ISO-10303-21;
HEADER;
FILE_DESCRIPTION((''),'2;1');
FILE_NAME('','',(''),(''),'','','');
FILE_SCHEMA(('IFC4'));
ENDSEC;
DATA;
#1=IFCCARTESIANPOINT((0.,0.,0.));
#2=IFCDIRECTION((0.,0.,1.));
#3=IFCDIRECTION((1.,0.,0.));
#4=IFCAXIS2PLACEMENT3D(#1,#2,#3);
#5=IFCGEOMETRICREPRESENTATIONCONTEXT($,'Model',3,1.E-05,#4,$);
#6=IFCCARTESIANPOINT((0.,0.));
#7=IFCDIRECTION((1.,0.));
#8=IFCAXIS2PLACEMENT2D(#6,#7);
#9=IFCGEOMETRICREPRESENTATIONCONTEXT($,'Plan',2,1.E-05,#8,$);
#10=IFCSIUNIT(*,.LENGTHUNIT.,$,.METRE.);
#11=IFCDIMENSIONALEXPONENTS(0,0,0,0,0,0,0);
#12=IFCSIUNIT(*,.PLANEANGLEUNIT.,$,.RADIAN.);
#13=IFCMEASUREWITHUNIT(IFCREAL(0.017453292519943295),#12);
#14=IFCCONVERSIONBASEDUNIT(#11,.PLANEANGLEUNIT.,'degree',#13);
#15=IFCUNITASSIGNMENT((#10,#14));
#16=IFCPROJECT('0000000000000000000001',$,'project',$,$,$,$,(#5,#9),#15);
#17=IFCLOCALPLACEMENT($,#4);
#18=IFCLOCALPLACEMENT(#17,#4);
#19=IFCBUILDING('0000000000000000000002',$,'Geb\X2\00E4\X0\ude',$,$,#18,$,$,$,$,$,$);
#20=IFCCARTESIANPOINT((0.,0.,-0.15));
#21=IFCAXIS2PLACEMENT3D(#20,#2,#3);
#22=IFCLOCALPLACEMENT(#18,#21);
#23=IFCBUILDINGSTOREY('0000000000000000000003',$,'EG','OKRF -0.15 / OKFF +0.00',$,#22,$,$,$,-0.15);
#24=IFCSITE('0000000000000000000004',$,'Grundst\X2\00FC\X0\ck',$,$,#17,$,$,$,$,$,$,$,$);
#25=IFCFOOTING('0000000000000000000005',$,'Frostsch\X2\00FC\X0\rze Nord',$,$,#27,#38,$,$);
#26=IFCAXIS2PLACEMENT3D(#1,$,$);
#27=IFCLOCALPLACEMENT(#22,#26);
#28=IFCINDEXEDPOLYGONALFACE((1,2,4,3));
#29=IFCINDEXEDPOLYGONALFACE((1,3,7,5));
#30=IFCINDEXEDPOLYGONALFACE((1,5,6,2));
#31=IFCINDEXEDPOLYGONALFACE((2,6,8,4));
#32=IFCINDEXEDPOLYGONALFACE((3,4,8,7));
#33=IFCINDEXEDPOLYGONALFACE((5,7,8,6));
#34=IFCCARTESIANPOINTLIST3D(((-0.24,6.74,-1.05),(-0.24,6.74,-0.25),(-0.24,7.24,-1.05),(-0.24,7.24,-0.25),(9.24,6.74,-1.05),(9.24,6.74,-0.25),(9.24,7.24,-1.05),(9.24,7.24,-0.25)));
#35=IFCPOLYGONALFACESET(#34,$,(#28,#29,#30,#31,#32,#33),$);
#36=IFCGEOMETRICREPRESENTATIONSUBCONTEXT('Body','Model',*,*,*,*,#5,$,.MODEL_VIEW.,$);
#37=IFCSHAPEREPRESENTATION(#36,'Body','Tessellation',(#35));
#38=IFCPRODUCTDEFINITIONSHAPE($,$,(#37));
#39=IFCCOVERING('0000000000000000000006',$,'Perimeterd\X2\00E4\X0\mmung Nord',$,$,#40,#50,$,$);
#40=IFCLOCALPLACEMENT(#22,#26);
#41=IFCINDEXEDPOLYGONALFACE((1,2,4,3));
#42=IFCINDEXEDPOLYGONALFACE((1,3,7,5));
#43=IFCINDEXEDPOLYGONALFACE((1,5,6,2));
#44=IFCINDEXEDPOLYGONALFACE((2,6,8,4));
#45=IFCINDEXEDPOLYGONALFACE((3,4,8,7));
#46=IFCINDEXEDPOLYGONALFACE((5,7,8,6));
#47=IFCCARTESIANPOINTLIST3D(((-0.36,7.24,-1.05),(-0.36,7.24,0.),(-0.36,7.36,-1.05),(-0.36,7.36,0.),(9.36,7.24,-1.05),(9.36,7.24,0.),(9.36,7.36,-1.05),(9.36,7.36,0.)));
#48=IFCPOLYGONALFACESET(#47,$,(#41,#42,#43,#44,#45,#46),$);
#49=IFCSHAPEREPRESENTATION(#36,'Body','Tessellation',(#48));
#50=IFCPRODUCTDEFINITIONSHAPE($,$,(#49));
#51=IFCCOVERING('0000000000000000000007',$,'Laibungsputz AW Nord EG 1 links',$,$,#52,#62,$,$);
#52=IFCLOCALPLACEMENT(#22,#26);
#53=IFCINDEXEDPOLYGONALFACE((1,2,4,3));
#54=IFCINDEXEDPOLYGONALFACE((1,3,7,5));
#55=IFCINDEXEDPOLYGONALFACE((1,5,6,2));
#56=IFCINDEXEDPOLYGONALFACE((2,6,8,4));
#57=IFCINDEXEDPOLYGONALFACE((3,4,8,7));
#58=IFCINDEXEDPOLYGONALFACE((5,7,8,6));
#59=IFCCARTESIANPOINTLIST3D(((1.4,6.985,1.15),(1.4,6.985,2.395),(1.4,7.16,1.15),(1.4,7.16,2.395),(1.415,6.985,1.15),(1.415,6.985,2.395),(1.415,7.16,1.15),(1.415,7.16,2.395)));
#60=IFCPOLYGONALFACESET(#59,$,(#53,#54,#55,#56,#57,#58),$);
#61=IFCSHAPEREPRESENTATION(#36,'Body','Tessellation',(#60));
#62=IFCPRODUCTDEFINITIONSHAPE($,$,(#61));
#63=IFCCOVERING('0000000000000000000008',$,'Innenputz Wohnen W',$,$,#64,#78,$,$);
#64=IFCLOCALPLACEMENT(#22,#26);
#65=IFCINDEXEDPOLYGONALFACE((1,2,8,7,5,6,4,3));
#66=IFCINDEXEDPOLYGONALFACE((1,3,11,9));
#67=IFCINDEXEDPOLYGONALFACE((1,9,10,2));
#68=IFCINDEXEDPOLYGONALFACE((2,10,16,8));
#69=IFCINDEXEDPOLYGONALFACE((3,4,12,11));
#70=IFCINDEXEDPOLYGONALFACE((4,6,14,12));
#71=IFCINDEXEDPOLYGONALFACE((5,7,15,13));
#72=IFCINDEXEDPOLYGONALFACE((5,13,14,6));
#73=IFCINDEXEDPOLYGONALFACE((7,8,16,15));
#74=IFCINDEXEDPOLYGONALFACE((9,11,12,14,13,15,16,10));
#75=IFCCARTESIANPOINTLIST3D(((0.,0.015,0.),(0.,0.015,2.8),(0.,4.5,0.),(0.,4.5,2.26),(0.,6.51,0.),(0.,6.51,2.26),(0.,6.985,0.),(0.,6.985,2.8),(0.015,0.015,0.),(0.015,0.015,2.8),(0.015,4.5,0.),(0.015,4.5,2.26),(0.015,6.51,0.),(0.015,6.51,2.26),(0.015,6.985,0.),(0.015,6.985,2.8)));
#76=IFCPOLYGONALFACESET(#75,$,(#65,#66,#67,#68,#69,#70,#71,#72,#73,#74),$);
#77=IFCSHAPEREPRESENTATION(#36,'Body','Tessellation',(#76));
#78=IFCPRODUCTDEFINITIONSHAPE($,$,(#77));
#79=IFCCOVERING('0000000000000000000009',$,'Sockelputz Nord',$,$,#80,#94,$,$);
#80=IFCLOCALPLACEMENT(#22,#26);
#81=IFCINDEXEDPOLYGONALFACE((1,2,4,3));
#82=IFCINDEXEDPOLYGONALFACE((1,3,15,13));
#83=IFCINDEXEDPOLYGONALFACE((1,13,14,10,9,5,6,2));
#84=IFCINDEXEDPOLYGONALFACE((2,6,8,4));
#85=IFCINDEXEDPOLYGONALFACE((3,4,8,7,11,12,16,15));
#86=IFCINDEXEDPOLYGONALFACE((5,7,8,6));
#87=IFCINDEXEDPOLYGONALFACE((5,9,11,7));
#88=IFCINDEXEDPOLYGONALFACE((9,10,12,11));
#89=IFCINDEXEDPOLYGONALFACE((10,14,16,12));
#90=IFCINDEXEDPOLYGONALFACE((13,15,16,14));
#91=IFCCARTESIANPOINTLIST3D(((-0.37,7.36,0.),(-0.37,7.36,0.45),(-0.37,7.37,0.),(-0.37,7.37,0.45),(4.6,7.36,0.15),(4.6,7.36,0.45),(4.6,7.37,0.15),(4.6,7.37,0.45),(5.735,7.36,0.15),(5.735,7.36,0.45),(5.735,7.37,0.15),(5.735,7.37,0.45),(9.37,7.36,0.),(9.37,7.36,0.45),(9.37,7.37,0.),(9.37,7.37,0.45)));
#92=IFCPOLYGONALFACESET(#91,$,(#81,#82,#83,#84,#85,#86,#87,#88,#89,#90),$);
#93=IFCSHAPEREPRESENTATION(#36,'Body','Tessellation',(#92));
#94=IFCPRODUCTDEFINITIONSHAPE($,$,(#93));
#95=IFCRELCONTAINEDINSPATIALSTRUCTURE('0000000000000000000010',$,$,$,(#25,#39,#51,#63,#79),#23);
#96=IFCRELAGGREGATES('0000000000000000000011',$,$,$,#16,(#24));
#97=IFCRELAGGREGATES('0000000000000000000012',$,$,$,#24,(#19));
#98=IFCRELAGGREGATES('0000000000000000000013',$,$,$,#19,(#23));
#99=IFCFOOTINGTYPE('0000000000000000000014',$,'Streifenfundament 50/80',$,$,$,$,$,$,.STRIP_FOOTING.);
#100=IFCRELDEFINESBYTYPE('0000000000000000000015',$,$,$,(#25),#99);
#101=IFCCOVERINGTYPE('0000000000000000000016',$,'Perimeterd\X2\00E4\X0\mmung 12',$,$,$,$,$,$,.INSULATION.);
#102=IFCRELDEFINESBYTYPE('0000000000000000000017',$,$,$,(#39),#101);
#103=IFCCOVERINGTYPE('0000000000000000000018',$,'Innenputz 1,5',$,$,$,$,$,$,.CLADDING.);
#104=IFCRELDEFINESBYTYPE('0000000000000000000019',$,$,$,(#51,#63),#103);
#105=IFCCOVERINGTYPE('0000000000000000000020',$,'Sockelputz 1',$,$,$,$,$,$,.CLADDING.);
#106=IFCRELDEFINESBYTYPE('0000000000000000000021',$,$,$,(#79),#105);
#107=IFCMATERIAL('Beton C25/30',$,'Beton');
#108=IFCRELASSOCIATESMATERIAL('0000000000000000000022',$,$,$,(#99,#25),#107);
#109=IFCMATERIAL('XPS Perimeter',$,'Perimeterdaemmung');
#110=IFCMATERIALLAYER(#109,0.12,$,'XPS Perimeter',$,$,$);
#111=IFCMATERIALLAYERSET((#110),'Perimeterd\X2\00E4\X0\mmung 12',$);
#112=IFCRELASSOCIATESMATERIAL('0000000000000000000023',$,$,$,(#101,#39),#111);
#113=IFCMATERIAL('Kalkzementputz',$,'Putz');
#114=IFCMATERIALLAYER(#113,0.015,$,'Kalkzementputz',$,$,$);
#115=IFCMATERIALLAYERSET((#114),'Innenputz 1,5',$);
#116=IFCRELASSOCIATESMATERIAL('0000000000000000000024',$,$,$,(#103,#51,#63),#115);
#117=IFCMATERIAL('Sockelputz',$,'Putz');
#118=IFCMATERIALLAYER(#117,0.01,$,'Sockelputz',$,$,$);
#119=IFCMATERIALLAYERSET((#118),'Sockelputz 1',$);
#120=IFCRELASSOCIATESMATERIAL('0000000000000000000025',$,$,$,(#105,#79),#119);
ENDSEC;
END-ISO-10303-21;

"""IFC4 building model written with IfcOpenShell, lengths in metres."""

from ifc_helpers import new_model, entity, si_unit, converted_unit, frame, origin_with_axes, origin_2d_with_axis, place, context, subcontext, project, spatial, polyline, indexed_curve, rectangle, outline, extrude, material, layer, layer_set, layer_usage, material_profile, profile_set, profile_usage, type_object, element, save


model = new_model("IFC4")

# Units and contexts
model_context = context("Model", 3, precision=1e-05, world=origin_with_axes())
plan_context = context("Plan", 2, precision=1e-05, world=origin_2d_with_axis())
body_context_1 = subcontext(model_context, "Body", "Model", "MODEL_VIEW")
ifc_project = project(units=[si_unit("LENGTHUNIT", "METRE"), converted_unit("PLANEANGLEUNIT", "degree", entity("IfcReal", 0.017453292519943295), si_unit("PLANEANGLEUNIT", "RADIAN"), dimensions=[0, 0, 0, 0, 0, 0, 0])], contexts=[model_context, plan_context])

# Site, building, storey
site_placement = place(None, origin_with_axes())
site = spatial("IfcSite", under=ifc_project, at=site_placement, Name="Grundstück")
building_placement = place(site_placement, origin_with_axes())
building = spatial("IfcBuilding", under=site, at=building_placement, Name="Gebäude")
storey_placement = place(building_placement, frame((0.0, 0.0, -0.15), z_axis=(0.0, 0.0, 1.0), x_axis=(1.0, 0.0, 0.0)))
storey = spatial("IfcBuildingStorey", under=building, at=storey_placement, Name="EG", Description="OKRF -0.15 / OKFF +0.00", Elevation=-0.15)

# Footing
ifc_material_1 = material(Name="Beton C25/30", Category="Beton")
ifc_material_profile = material_profile(ifc_material_1, rectangle(XDim=0.5, YDim=0.8))
ifc_profile_set = profile_set([ifc_material_profile], Name="Streifenfundament 50/80")
ifc_profile_usage = profile_usage(ifc_profile_set)
footing_type = type_object("IfcFootingType", Name="Streifenfundament 50/80", PredefinedType="STRIP_FOOTING", material=ifc_profile_set)
footing_placement = place(storey_placement, frame((-0.24, 6.99, -0.65), z_axis=(1.0, 0.0, 0.0), x_axis=(0.0, 1.0, 0.0)))
element("IfcFooting", 1, at=footing_placement, inside=storey, type_object=footing_type, material=ifc_profile_usage, Name="Frostschürze Nord", context=body_context_1, shape_type="SweptSolid", body=[
    extrude(rectangle(XDim=0.5, YDim=0.8), origin_with_axes(), (0.0, 0.0, 1.0), 9.48),
])

# Coverings
ifc_material_2 = material(Name="XPS Perimeter", Category="Perimeterdaemmung")
ifc_layer_1 = layer(ifc_material_2, 0.12, Name="XPS Perimeter")
ifc_layer_set_1 = layer_set([ifc_layer_1], Name="Perimeterdämmung 12")
ifc_layer_usage_1 = layer_usage(ifc_layer_set_1, "AXIS2", "POSITIVE", 0.0)
covering_type_1 = type_object("IfcCoveringType", Name="Perimeterdämmung 12", PredefinedType="INSULATION", material=ifc_layer_set_1)
covering_1_placement = place(storey_placement, frame((-0.36, 7.24, -1.05), z_axis=(0.0, 0.0, 1.0), x_axis=(1.0, 0.0, 0.0)))
element("IfcCovering", 2, at=covering_1_placement, inside=storey, type_object=covering_type_1, material=ifc_layer_usage_1, Name="Perimeterdämmung Nord", context=body_context_1, shape_type="SweptSolid", body=[
    extrude(outline(indexed_curve([(0.0, 0.0), (0.0, 0.12), (9.72, 0.12), (9.72, 0.0), (0.0, 0.0)], self_intersect=False)), origin_with_axes(), (0.0, 0.0, 1.0), 1.05),
])
ifc_material_3 = material(Name="Kalkzementputz", Category="Putz")
ifc_layer_2 = layer(ifc_material_3, 0.015, Name="Kalkzementputz")
ifc_layer_set_2 = layer_set([ifc_layer_2], Name="Innenputz 1,5")
ifc_layer_usage_2 = layer_usage(ifc_layer_set_2, "AXIS1", "POSITIVE", 1.4)
covering_type_2 = type_object("IfcCoveringType", Name="Innenputz 1,5", PredefinedType="CLADDING", material=ifc_layer_set_2)
covering_2_placement = place(storey_placement, frame((0.0, 7.0, 0.0), z_axis=(0.0, 0.0, 1.0), x_axis=(1.0, 0.0, 0.0)))
element("IfcCovering", 3, at=covering_2_placement, inside=storey, type_object=covering_type_2, material=ifc_layer_usage_2, Name="Laibungsputz AW Nord EG 1 links", context=body_context_1, shape_type="SweptSolid", body=[
    extrude(outline(polyline([(-0.015, 1.15), (0.16, 1.15), (0.16, 2.395), (-0.015, 2.395), (-0.015, 1.15)])), frame((1.4, 0.0, 0.0), z_axis=(1.0, 0.0, 0.0), x_axis=(0.0, 1.0, 0.0)), (0.0, 0.0, 1.0), 0.015),
])

# Covering, opening
ifc_layer_usage_3 = layer_usage(ifc_layer_set_2, "AXIS2", "POSITIVE", 0.0)
covering_3_placement = place(storey_placement, frame((0.0, 6.985, 0.0), z_axis=(0.0, 0.0, 1.0), x_axis=(0.0, -1.0, 0.0)))
covering_3 = element("IfcCovering", 4, at=covering_3_placement, inside=storey, type_object=covering_type_2, material=ifc_layer_usage_3, Name="Innenputz Wohnen W", context=body_context_1, shape_type="SweptSolid", body=[
    extrude(outline(indexed_curve([(0.0, 0.0), (0.0, 0.015), (6.97, 0.015), (6.97, 0.0), (0.0, 0.0)], self_intersect=False)), origin_with_axes(), (0.0, 0.0, 1.0), 2.8),
])
opening_1_placement = place(covering_3_placement, frame((0.475, -0.05, 0.0), z_axis=(0.0, 0.0, 1.0), x_axis=(1.0, 0.0, 0.0)))
element("IfcOpeningElement", 5, at=opening_1_placement, cuts=covering_3, context=body_context_1, shape_type="SweptSolid", body=[
    extrude(outline(indexed_curve([(0.0, 0.0), (0.0, 0.115), (2.01, 0.115), (2.01, 0.0), (0.0, 0.0)], self_intersect=False)), origin_with_axes(), (0.0, 0.0, 1.0), 2.26),
])

# Covering, opening
ifc_material_4 = material(Name="Sockelputz", Category="Putz")
ifc_layer_3 = layer(ifc_material_4, 0.01, Name="Sockelputz")
ifc_layer_set_3 = layer_set([ifc_layer_3], Name="Sockelputz 1")
ifc_layer_usage_4 = layer_usage(ifc_layer_set_3, "AXIS2", "POSITIVE", 0.0)
covering_type_3 = type_object("IfcCoveringType", Name="Sockelputz 1", PredefinedType="CLADDING", material=ifc_layer_set_3)
covering_4_placement = place(storey_placement, frame((-0.37, 7.36, 0.0), z_axis=(0.0, 0.0, 1.0), x_axis=(1.0, 0.0, 0.0)))
covering_4 = element("IfcCovering", 6, at=covering_4_placement, inside=storey, type_object=covering_type_3, material=ifc_layer_usage_4, Name="Sockelputz Nord", context=body_context_1, shape_type="SweptSolid", body=[
    extrude(outline(indexed_curve([(0.0, 0.0), (0.0, 0.01), (9.74, 0.01), (9.74, 0.0), (0.0, 0.0)], self_intersect=False)), origin_with_axes(), (0.0, 0.0, 1.0), 0.45),
])
opening_2_placement = place(covering_4_placement, frame((4.97, -0.05, 0.15), z_axis=(0.0, 0.0, 1.0), x_axis=(1.0, 0.0, 0.0)))
element("IfcOpeningElement", 7, at=opening_2_placement, cuts=covering_4, context=body_context_1, shape_type="SweptSolid", body=[
    extrude(outline(indexed_curve([(0.0, 0.0), (0.0, 0.11), (1.135, 0.11), (1.135, 0.0), (0.0, 0.0)], self_intersect=False)), origin_with_axes(), (0.0, 0.0, 1.0), 0.3),
])

save(model, "model.ifc")
